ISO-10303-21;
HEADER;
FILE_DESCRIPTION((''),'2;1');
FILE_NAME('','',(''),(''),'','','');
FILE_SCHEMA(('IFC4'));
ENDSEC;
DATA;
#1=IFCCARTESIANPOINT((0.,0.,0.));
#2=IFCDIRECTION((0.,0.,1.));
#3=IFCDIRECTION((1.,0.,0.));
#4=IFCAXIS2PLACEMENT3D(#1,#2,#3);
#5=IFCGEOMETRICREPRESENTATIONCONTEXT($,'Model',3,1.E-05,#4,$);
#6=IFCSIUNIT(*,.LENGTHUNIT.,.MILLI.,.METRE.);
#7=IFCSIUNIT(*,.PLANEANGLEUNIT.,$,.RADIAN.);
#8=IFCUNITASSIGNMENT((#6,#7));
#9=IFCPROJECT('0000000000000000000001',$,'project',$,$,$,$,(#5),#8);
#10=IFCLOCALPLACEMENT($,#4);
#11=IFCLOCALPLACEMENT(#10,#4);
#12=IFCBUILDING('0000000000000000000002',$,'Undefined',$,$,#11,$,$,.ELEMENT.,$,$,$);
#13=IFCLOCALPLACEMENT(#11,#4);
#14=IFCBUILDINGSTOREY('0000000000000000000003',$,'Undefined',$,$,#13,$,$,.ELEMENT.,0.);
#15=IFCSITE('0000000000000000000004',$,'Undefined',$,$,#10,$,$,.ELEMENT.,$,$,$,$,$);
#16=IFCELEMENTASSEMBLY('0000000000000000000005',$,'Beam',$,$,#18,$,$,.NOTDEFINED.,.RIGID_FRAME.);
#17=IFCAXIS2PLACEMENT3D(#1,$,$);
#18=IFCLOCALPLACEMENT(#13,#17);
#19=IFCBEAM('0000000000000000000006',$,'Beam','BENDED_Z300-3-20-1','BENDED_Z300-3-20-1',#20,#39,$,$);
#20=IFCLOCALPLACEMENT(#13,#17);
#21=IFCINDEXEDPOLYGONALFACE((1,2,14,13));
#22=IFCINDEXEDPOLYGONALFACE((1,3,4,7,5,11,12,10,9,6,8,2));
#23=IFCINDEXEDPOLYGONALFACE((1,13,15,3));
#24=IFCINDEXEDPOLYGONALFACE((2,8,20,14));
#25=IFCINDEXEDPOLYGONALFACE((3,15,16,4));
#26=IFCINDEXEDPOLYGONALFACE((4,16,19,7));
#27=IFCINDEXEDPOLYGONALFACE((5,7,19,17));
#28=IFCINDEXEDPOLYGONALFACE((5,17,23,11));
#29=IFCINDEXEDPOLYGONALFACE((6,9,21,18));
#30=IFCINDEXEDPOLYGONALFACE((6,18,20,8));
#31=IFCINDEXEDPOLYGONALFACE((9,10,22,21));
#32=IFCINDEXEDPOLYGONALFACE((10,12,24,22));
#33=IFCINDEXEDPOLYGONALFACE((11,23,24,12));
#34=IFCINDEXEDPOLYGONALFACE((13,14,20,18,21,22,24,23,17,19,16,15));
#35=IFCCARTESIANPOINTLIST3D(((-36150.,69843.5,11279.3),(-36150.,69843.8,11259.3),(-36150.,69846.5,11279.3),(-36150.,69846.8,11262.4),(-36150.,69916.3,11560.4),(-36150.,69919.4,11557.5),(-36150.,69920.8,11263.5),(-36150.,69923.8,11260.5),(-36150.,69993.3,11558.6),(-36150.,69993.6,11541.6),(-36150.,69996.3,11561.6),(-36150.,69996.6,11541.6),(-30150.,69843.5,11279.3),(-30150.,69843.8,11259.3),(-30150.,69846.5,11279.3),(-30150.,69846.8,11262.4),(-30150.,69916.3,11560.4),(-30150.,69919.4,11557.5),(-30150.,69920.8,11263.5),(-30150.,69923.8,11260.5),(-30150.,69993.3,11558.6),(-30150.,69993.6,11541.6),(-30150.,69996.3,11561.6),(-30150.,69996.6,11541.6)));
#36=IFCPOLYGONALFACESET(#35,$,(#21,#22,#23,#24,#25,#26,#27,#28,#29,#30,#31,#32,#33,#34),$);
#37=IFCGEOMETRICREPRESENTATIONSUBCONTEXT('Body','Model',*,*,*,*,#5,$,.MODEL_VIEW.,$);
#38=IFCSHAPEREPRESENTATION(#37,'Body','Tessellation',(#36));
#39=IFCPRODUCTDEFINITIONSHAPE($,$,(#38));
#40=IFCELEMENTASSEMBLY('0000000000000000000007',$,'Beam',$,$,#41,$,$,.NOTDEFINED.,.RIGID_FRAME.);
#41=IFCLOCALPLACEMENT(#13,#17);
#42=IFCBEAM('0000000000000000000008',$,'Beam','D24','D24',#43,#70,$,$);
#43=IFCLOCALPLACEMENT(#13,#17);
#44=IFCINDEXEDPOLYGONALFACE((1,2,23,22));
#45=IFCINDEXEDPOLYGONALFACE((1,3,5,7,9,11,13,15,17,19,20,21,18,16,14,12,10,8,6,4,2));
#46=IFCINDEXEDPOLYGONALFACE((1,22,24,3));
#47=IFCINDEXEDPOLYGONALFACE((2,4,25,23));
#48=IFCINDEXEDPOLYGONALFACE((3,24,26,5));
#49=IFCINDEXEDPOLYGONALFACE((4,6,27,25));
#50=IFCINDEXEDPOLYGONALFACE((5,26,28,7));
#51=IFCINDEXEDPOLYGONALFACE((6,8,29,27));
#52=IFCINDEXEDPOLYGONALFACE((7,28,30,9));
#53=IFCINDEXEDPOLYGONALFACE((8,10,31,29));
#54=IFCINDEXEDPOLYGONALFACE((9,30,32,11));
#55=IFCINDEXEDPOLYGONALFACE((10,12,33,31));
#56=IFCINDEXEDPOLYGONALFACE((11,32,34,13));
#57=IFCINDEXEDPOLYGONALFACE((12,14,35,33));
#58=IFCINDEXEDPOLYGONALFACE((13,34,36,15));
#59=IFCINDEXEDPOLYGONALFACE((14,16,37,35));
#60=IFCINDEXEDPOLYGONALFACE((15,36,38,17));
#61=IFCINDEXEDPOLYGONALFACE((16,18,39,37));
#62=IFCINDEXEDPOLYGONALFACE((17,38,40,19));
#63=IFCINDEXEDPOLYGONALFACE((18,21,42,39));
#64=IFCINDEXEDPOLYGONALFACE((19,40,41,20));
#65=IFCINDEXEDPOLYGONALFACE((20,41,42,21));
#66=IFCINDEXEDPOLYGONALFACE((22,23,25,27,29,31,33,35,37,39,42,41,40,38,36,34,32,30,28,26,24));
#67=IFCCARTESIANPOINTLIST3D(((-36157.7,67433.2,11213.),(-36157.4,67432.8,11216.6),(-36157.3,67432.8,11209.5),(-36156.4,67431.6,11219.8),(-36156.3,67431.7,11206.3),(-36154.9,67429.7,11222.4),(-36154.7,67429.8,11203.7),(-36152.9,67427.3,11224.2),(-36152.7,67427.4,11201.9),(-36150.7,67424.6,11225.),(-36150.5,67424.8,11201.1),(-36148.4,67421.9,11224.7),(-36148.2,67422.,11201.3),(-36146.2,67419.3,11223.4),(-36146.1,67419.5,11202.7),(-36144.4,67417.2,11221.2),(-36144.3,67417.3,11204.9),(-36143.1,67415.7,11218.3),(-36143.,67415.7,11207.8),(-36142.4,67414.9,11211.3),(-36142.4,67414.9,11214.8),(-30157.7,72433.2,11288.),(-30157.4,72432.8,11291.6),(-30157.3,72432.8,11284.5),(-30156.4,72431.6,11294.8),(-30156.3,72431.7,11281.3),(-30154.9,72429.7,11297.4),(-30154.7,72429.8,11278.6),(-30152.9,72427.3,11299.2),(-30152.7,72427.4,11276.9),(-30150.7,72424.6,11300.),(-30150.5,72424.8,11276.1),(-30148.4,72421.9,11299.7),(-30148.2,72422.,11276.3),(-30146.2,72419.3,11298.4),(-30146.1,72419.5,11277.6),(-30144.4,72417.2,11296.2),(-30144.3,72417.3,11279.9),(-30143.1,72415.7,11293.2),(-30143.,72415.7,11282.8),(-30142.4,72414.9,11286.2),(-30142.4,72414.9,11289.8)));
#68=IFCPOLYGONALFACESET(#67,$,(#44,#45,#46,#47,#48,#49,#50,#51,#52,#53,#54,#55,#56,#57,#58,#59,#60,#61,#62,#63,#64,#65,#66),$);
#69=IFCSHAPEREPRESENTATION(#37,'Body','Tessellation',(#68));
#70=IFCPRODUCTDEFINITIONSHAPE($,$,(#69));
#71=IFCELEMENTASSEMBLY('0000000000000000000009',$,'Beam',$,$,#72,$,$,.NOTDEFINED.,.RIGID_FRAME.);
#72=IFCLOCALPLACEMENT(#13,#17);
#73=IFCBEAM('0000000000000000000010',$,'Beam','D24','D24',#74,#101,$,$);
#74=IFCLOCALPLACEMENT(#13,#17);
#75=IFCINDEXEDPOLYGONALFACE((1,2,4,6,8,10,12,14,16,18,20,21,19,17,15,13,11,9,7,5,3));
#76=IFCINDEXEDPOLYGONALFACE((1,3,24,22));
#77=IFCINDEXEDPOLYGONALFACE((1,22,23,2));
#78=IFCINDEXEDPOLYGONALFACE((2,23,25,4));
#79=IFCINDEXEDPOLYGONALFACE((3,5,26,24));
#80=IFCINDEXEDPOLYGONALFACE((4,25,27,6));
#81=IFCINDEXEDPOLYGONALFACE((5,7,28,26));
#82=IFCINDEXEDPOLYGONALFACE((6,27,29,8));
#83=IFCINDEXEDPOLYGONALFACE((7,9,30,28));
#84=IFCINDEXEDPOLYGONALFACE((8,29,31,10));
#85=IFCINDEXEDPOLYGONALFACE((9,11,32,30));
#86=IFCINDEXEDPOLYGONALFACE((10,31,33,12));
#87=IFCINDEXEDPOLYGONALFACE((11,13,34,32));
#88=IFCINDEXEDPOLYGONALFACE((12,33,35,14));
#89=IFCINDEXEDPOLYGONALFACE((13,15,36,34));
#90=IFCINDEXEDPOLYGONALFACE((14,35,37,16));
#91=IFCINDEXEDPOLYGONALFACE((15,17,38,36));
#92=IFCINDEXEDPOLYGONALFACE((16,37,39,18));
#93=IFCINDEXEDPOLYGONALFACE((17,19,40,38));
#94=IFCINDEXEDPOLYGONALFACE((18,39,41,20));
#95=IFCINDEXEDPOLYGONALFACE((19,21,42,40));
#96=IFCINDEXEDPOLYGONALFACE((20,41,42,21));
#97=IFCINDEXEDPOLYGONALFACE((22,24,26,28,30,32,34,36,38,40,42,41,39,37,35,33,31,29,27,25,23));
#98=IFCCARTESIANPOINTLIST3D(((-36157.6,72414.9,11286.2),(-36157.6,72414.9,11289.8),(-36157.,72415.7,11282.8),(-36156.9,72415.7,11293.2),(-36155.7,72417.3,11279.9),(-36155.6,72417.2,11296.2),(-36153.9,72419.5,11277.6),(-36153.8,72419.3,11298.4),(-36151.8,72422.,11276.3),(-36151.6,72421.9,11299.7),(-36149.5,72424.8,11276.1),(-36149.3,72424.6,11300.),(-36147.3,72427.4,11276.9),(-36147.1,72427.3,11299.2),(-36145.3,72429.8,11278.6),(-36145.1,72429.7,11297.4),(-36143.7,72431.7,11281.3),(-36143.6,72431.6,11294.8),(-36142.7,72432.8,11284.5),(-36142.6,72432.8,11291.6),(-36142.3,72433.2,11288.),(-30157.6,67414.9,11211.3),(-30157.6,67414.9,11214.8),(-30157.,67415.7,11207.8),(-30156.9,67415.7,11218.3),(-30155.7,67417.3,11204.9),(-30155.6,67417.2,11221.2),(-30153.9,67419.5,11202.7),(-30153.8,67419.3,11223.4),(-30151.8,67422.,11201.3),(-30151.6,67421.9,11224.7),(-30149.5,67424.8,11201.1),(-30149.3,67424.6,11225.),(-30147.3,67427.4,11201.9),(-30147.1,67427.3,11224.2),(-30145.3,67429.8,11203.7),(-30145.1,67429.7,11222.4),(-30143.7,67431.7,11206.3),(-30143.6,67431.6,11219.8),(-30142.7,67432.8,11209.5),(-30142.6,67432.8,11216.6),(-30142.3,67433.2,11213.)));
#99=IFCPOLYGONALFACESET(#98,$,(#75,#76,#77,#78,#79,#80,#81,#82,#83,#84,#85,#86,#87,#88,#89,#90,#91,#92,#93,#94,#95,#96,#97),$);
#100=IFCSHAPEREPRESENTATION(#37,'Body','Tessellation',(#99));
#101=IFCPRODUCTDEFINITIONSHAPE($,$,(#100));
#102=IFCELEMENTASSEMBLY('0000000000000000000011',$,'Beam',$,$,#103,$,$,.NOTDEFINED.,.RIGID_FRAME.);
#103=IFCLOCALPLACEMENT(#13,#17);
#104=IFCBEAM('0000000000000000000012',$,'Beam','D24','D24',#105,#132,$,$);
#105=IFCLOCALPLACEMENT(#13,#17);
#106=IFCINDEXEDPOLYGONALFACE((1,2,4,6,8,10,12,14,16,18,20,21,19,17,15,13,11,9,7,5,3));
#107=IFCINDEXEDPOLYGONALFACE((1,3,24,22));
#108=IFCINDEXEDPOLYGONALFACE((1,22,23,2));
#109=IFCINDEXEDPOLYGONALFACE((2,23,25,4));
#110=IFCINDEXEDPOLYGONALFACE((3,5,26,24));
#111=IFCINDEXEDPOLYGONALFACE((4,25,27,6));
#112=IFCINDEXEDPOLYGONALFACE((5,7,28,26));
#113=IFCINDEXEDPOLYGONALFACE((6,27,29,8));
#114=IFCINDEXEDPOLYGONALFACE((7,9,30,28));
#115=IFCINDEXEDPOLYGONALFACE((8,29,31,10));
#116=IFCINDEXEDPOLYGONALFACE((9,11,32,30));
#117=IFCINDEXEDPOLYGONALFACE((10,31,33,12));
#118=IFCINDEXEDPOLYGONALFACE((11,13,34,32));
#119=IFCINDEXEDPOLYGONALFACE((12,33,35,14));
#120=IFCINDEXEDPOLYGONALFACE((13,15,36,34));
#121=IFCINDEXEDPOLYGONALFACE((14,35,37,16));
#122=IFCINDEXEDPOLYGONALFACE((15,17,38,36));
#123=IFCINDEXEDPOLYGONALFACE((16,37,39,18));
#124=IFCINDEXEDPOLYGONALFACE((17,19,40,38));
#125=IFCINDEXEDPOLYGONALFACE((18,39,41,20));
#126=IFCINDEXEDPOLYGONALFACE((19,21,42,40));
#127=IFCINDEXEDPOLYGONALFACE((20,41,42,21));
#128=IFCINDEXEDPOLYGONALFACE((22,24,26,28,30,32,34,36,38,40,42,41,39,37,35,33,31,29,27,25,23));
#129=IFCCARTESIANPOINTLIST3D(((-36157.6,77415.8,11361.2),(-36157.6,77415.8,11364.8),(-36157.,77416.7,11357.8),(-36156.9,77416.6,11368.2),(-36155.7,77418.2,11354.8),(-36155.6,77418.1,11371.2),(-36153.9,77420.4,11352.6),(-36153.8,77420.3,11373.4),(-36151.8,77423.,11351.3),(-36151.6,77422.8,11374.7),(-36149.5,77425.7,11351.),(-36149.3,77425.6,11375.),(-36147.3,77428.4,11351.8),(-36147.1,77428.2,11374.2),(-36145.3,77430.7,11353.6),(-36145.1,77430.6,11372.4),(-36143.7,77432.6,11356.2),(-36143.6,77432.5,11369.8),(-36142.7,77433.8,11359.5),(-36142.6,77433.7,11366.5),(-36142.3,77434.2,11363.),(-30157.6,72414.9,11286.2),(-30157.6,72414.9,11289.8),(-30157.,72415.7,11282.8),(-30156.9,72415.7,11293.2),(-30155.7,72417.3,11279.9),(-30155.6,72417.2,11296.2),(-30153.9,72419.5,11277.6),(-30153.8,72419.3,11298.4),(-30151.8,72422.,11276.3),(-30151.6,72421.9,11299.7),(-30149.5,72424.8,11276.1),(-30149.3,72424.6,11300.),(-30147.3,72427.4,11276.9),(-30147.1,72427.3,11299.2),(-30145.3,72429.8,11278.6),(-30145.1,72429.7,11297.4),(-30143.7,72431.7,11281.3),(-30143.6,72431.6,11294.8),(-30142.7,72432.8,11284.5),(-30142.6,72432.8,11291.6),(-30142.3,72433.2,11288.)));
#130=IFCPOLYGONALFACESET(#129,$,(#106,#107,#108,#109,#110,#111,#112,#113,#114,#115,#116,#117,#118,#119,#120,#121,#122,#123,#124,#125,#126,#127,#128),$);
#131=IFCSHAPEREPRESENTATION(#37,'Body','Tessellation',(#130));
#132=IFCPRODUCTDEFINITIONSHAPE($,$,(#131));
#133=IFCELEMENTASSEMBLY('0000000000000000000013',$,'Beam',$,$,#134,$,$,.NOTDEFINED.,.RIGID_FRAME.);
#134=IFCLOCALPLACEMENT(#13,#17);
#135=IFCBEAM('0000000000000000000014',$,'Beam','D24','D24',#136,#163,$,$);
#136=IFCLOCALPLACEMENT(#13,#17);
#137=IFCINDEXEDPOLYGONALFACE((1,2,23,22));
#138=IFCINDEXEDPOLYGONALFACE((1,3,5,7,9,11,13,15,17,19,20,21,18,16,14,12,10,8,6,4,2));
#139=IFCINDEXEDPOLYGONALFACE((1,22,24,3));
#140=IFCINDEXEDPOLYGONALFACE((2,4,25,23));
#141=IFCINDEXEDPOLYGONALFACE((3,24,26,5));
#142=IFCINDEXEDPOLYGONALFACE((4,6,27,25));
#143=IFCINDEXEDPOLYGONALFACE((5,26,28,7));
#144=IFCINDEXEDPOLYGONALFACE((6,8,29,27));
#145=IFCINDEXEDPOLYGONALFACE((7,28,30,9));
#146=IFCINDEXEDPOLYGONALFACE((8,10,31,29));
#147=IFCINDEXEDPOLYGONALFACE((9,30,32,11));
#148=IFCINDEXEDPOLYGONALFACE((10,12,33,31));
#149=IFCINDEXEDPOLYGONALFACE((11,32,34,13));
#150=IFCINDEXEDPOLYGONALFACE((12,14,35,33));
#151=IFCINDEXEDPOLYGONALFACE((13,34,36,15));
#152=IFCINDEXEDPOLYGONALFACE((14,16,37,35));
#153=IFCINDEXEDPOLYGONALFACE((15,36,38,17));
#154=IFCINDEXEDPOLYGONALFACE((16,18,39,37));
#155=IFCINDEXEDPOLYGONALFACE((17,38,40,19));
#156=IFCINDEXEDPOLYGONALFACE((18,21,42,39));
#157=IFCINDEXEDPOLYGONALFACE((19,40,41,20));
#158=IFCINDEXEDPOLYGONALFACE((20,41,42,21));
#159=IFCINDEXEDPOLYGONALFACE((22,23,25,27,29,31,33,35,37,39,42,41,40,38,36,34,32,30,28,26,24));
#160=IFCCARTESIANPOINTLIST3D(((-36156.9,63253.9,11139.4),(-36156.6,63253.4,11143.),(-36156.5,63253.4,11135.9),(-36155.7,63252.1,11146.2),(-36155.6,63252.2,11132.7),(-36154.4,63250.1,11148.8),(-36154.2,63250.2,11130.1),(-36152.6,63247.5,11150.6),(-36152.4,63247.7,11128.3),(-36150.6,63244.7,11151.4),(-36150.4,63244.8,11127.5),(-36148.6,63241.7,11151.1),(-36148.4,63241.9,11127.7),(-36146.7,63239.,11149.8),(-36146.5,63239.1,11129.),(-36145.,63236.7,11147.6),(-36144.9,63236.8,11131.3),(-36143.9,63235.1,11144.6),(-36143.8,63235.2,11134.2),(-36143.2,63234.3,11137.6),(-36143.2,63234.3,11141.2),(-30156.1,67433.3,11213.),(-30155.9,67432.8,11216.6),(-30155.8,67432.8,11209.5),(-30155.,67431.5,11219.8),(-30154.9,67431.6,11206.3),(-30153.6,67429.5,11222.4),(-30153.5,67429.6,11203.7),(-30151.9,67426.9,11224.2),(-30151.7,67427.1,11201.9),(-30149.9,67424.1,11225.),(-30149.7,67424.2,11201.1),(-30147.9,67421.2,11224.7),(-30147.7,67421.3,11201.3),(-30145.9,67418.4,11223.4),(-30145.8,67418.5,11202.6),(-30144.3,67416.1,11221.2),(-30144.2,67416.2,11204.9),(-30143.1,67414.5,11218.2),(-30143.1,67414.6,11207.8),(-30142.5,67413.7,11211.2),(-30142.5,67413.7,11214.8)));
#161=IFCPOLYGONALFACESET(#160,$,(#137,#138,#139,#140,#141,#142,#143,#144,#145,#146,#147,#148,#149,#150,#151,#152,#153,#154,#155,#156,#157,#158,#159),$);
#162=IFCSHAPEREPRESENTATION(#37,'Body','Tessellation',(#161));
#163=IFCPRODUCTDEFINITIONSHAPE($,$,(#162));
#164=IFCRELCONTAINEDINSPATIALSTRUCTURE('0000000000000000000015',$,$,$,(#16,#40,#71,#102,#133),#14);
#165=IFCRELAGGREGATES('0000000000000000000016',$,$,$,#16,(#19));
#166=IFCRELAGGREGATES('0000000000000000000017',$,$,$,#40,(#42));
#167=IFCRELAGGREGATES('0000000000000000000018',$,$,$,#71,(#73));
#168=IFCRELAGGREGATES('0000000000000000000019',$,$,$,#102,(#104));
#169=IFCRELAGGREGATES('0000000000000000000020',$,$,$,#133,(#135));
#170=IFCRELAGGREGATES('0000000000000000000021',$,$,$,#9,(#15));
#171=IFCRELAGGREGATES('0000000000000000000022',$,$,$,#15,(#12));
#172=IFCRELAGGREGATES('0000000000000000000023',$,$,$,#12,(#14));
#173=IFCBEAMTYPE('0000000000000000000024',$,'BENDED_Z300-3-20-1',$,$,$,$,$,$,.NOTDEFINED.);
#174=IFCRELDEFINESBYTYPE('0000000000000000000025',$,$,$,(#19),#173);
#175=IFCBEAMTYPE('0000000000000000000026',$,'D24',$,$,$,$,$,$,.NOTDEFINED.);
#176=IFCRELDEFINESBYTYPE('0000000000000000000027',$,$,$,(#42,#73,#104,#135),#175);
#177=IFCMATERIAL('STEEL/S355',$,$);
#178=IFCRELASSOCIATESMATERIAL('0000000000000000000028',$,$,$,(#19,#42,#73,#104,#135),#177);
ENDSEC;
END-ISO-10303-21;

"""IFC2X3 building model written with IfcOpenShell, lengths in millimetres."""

from ifc_helpers import new_model, si_unit, frame, origin_with_axes, origin_2d_with_axis, place, context, subcontext, project, spatial, polyline, circle, outline, extrude, material, type_object, element, aggregate, save


model = new_model("IFC2X3")

# Units and contexts
model_context = context("Model", 3, precision=1e-05, world=origin_with_axes())
body_context = subcontext(model_context, "Body", "Model", "MODEL_VIEW")
ifc_project = project(units=[si_unit("LENGTHUNIT", "METRE", prefix="MILLI"), si_unit("PLANEANGLEUNIT", "RADIAN")], contexts=[model_context])

# Site, building, storey
site_placement = place(None, origin_with_axes())
site = spatial("IfcSite", under=ifc_project, at=site_placement, Name="Undefined", CompositionType="ELEMENT")
building_placement = place(site_placement, origin_with_axes())
building = spatial("IfcBuilding", under=site, at=building_placement, Name="Undefined", CompositionType="ELEMENT")
storey_placement = place(building_placement, origin_with_axes())
storey = spatial("IfcBuildingStorey", under=building, at=storey_placement, Name="Undefined", CompositionType="ELEMENT", Elevation=0.0)

# Shared definitions
ifc_material = material(Name="STEEL/S355")

# Element assemblies, beams
beam_type_1 = type_object("IfcBeamType", Name="BENDED_Z300-3-20-1", PredefinedType="NOTDEFINED")
assembly_1_placement = place(storey_placement, origin_with_axes())
assembly_1 = element("IfcElementAssembly", 1, at=assembly_1_placement, inside=storey, Name="Beam", AssemblyPlace="NOTDEFINED", PredefinedType="RIGID_FRAME")
beam_1_placement = place(assembly_1_placement, frame((-30150.0, 69920.1, 11410.5), z_axis=(0.0, -0.014963, 0.999888), x_axis=(-1.0, 0.0, 0.0)))
beam_1 = element("IfcBeam", 2, at=beam_1_placement, type_object=beam_type_1, material=ifc_material, Name="Beam", Description="BENDED_Z300-3-20-1", ObjectType="BENDED_Z300-3-20-1", context=body_context, shape_type="SweptSolid", body=[
    extrude(outline(polyline([(1.5, -150.0), (-78.5, -150.0), (-78.5, -130.0), (-75.5, -130.0), (-75.5, -147.0), (-1.5, -147.0), (-1.5, 150.0), (78.5, 150.0), (78.5, 130.0), (75.5, 130.0), (75.5, 147.0), (1.5, 147.0), (1.5, -150.0)])), frame((6000.0, 0.0, 0.0), z_axis=(-1.0, 0.0, 0.0), x_axis=(0.0, -1.0, 0.0)), (0.0, 0.0, 1.0), 6000.0),
])
aggregate(assembly_1, [beam_1])
assembly_2_placement = place(storey_placement, origin_with_axes())
assembly_2 = element("IfcElementAssembly", 3, at=assembly_2_placement, inside=storey, Name="Beam", AssemblyPlace="NOTDEFINED", PredefinedType="RIGID_FRAME")
beam_type_2 = type_object("IfcBeamType", Name="D24", PredefinedType="NOTDEFINED")
beam_2_placement = place(assembly_2_placement, frame((-30150.0, 72424.0, 11288.0), z_axis=(-0.007375, -0.006146, 0.999954), x_axis=(-0.768186, -0.640155, -0.0096)))
beam_2 = element("IfcBeam", 4, at=beam_2_placement, type_object=beam_type_2, material=ifc_material, Name="Beam", Description="D24", ObjectType="D24", context=body_context, shape_type="SweptSolid", body=[
    extrude(circle(Radius=12.0, at=origin_2d_with_axis()), frame((7810.6, 0.0, 0.0), z_axis=(-1.0, 0.0, 0.0), x_axis=(0.0, -1.0, 0.0)), (0.0, 0.0, 1.0), 7810.6),
])
aggregate(assembly_2, [beam_2])
assembly_3_placement = place(storey_placement, origin_with_axes())
assembly_3 = element("IfcElementAssembly", 5, at=assembly_3_placement, inside=storey, Name="Beam", AssemblyPlace="NOTDEFINED", PredefinedType="RIGID_FRAME")
beam_3_placement = place(assembly_3_placement, frame((-30150.0, 67424.0, 11213.0), z_axis=(0.007375, -0.006146, 0.999954), x_axis=(-0.768186, 0.640155, 0.0096)))
beam_3 = element("IfcBeam", 6, at=beam_3_placement, type_object=beam_type_2, material=ifc_material, Name="Beam", Description="D24", ObjectType="D24", context=body_context, shape_type="SweptSolid", body=[
    extrude(circle(Radius=12.0, at=origin_2d_with_axis()), frame((7810.6, 0.0, 0.0), z_axis=(-1.0, 0.0, 0.0), x_axis=(0.0, -1.0, 0.0)), (0.0, 0.0, 1.0), 7810.6),
])
aggregate(assembly_3, [beam_3])
assembly_4_placement = place(storey_placement, origin_with_axes())
assembly_4 = element("IfcElementAssembly", 7, at=assembly_4_placement, inside=storey, Name="Beam", AssemblyPlace="NOTDEFINED", PredefinedType="RIGID_FRAME")
beam_4_placement = place(assembly_4_placement, frame((-30150.0, 72424.0, 11288.0), z_axis=(0.007372, -0.006145, 0.999954), x_axis=(-0.768127, 0.640225, 0.009598)))
beam_4 = element("IfcBeam", 8, at=beam_4_placement, type_object=beam_type_2, material=ifc_material, Name="Beam", Description="D24", ObjectType="D24", context=body_context, shape_type="SweptSolid", body=[
    extrude(circle(Radius=12.0, at=origin_2d_with_axis()), frame((7811.2, 0.0, 0.0), z_axis=(-1.0, 0.0, 0.0), x_axis=(0.0, -1.0, 0.0)), (0.0, 0.0, 1.0), 7811.2),
])
aggregate(assembly_4, [beam_4])
assembly_5_placement = place(storey_placement, origin_with_axes())
assembly_5 = element("IfcElementAssembly", 9, at=assembly_5_placement, inside=storey, Name="Beam", AssemblyPlace="NOTDEFINED", PredefinedType="RIGID_FRAME")
beam_5_placement = place(assembly_5_placement, frame((-30149.3, 67423.4, 11213.0), z_axis=(-0.008259, -0.005752, 0.999949), x_axis=(-0.820543, -0.571496, -0.010064)))
beam_5 = element("IfcBeam", 10, at=beam_5_placement, type_object=beam_type_2, material=ifc_material, Name="Beam", Description="D24", ObjectType="D24", context=body_context, shape_type="SweptSolid", body=[
    extrude(circle(Radius=12.0, at=origin_2d_with_axis()), frame((7313.1, 0.0, 0.0), z_axis=(-1.0, 0.0, 0.0), x_axis=(0.0, -1.0, 0.0)), (0.0, 0.0, 1.0), 7313.1),
])
aggregate(assembly_5, [beam_5])

save(model, "model.ifc")
